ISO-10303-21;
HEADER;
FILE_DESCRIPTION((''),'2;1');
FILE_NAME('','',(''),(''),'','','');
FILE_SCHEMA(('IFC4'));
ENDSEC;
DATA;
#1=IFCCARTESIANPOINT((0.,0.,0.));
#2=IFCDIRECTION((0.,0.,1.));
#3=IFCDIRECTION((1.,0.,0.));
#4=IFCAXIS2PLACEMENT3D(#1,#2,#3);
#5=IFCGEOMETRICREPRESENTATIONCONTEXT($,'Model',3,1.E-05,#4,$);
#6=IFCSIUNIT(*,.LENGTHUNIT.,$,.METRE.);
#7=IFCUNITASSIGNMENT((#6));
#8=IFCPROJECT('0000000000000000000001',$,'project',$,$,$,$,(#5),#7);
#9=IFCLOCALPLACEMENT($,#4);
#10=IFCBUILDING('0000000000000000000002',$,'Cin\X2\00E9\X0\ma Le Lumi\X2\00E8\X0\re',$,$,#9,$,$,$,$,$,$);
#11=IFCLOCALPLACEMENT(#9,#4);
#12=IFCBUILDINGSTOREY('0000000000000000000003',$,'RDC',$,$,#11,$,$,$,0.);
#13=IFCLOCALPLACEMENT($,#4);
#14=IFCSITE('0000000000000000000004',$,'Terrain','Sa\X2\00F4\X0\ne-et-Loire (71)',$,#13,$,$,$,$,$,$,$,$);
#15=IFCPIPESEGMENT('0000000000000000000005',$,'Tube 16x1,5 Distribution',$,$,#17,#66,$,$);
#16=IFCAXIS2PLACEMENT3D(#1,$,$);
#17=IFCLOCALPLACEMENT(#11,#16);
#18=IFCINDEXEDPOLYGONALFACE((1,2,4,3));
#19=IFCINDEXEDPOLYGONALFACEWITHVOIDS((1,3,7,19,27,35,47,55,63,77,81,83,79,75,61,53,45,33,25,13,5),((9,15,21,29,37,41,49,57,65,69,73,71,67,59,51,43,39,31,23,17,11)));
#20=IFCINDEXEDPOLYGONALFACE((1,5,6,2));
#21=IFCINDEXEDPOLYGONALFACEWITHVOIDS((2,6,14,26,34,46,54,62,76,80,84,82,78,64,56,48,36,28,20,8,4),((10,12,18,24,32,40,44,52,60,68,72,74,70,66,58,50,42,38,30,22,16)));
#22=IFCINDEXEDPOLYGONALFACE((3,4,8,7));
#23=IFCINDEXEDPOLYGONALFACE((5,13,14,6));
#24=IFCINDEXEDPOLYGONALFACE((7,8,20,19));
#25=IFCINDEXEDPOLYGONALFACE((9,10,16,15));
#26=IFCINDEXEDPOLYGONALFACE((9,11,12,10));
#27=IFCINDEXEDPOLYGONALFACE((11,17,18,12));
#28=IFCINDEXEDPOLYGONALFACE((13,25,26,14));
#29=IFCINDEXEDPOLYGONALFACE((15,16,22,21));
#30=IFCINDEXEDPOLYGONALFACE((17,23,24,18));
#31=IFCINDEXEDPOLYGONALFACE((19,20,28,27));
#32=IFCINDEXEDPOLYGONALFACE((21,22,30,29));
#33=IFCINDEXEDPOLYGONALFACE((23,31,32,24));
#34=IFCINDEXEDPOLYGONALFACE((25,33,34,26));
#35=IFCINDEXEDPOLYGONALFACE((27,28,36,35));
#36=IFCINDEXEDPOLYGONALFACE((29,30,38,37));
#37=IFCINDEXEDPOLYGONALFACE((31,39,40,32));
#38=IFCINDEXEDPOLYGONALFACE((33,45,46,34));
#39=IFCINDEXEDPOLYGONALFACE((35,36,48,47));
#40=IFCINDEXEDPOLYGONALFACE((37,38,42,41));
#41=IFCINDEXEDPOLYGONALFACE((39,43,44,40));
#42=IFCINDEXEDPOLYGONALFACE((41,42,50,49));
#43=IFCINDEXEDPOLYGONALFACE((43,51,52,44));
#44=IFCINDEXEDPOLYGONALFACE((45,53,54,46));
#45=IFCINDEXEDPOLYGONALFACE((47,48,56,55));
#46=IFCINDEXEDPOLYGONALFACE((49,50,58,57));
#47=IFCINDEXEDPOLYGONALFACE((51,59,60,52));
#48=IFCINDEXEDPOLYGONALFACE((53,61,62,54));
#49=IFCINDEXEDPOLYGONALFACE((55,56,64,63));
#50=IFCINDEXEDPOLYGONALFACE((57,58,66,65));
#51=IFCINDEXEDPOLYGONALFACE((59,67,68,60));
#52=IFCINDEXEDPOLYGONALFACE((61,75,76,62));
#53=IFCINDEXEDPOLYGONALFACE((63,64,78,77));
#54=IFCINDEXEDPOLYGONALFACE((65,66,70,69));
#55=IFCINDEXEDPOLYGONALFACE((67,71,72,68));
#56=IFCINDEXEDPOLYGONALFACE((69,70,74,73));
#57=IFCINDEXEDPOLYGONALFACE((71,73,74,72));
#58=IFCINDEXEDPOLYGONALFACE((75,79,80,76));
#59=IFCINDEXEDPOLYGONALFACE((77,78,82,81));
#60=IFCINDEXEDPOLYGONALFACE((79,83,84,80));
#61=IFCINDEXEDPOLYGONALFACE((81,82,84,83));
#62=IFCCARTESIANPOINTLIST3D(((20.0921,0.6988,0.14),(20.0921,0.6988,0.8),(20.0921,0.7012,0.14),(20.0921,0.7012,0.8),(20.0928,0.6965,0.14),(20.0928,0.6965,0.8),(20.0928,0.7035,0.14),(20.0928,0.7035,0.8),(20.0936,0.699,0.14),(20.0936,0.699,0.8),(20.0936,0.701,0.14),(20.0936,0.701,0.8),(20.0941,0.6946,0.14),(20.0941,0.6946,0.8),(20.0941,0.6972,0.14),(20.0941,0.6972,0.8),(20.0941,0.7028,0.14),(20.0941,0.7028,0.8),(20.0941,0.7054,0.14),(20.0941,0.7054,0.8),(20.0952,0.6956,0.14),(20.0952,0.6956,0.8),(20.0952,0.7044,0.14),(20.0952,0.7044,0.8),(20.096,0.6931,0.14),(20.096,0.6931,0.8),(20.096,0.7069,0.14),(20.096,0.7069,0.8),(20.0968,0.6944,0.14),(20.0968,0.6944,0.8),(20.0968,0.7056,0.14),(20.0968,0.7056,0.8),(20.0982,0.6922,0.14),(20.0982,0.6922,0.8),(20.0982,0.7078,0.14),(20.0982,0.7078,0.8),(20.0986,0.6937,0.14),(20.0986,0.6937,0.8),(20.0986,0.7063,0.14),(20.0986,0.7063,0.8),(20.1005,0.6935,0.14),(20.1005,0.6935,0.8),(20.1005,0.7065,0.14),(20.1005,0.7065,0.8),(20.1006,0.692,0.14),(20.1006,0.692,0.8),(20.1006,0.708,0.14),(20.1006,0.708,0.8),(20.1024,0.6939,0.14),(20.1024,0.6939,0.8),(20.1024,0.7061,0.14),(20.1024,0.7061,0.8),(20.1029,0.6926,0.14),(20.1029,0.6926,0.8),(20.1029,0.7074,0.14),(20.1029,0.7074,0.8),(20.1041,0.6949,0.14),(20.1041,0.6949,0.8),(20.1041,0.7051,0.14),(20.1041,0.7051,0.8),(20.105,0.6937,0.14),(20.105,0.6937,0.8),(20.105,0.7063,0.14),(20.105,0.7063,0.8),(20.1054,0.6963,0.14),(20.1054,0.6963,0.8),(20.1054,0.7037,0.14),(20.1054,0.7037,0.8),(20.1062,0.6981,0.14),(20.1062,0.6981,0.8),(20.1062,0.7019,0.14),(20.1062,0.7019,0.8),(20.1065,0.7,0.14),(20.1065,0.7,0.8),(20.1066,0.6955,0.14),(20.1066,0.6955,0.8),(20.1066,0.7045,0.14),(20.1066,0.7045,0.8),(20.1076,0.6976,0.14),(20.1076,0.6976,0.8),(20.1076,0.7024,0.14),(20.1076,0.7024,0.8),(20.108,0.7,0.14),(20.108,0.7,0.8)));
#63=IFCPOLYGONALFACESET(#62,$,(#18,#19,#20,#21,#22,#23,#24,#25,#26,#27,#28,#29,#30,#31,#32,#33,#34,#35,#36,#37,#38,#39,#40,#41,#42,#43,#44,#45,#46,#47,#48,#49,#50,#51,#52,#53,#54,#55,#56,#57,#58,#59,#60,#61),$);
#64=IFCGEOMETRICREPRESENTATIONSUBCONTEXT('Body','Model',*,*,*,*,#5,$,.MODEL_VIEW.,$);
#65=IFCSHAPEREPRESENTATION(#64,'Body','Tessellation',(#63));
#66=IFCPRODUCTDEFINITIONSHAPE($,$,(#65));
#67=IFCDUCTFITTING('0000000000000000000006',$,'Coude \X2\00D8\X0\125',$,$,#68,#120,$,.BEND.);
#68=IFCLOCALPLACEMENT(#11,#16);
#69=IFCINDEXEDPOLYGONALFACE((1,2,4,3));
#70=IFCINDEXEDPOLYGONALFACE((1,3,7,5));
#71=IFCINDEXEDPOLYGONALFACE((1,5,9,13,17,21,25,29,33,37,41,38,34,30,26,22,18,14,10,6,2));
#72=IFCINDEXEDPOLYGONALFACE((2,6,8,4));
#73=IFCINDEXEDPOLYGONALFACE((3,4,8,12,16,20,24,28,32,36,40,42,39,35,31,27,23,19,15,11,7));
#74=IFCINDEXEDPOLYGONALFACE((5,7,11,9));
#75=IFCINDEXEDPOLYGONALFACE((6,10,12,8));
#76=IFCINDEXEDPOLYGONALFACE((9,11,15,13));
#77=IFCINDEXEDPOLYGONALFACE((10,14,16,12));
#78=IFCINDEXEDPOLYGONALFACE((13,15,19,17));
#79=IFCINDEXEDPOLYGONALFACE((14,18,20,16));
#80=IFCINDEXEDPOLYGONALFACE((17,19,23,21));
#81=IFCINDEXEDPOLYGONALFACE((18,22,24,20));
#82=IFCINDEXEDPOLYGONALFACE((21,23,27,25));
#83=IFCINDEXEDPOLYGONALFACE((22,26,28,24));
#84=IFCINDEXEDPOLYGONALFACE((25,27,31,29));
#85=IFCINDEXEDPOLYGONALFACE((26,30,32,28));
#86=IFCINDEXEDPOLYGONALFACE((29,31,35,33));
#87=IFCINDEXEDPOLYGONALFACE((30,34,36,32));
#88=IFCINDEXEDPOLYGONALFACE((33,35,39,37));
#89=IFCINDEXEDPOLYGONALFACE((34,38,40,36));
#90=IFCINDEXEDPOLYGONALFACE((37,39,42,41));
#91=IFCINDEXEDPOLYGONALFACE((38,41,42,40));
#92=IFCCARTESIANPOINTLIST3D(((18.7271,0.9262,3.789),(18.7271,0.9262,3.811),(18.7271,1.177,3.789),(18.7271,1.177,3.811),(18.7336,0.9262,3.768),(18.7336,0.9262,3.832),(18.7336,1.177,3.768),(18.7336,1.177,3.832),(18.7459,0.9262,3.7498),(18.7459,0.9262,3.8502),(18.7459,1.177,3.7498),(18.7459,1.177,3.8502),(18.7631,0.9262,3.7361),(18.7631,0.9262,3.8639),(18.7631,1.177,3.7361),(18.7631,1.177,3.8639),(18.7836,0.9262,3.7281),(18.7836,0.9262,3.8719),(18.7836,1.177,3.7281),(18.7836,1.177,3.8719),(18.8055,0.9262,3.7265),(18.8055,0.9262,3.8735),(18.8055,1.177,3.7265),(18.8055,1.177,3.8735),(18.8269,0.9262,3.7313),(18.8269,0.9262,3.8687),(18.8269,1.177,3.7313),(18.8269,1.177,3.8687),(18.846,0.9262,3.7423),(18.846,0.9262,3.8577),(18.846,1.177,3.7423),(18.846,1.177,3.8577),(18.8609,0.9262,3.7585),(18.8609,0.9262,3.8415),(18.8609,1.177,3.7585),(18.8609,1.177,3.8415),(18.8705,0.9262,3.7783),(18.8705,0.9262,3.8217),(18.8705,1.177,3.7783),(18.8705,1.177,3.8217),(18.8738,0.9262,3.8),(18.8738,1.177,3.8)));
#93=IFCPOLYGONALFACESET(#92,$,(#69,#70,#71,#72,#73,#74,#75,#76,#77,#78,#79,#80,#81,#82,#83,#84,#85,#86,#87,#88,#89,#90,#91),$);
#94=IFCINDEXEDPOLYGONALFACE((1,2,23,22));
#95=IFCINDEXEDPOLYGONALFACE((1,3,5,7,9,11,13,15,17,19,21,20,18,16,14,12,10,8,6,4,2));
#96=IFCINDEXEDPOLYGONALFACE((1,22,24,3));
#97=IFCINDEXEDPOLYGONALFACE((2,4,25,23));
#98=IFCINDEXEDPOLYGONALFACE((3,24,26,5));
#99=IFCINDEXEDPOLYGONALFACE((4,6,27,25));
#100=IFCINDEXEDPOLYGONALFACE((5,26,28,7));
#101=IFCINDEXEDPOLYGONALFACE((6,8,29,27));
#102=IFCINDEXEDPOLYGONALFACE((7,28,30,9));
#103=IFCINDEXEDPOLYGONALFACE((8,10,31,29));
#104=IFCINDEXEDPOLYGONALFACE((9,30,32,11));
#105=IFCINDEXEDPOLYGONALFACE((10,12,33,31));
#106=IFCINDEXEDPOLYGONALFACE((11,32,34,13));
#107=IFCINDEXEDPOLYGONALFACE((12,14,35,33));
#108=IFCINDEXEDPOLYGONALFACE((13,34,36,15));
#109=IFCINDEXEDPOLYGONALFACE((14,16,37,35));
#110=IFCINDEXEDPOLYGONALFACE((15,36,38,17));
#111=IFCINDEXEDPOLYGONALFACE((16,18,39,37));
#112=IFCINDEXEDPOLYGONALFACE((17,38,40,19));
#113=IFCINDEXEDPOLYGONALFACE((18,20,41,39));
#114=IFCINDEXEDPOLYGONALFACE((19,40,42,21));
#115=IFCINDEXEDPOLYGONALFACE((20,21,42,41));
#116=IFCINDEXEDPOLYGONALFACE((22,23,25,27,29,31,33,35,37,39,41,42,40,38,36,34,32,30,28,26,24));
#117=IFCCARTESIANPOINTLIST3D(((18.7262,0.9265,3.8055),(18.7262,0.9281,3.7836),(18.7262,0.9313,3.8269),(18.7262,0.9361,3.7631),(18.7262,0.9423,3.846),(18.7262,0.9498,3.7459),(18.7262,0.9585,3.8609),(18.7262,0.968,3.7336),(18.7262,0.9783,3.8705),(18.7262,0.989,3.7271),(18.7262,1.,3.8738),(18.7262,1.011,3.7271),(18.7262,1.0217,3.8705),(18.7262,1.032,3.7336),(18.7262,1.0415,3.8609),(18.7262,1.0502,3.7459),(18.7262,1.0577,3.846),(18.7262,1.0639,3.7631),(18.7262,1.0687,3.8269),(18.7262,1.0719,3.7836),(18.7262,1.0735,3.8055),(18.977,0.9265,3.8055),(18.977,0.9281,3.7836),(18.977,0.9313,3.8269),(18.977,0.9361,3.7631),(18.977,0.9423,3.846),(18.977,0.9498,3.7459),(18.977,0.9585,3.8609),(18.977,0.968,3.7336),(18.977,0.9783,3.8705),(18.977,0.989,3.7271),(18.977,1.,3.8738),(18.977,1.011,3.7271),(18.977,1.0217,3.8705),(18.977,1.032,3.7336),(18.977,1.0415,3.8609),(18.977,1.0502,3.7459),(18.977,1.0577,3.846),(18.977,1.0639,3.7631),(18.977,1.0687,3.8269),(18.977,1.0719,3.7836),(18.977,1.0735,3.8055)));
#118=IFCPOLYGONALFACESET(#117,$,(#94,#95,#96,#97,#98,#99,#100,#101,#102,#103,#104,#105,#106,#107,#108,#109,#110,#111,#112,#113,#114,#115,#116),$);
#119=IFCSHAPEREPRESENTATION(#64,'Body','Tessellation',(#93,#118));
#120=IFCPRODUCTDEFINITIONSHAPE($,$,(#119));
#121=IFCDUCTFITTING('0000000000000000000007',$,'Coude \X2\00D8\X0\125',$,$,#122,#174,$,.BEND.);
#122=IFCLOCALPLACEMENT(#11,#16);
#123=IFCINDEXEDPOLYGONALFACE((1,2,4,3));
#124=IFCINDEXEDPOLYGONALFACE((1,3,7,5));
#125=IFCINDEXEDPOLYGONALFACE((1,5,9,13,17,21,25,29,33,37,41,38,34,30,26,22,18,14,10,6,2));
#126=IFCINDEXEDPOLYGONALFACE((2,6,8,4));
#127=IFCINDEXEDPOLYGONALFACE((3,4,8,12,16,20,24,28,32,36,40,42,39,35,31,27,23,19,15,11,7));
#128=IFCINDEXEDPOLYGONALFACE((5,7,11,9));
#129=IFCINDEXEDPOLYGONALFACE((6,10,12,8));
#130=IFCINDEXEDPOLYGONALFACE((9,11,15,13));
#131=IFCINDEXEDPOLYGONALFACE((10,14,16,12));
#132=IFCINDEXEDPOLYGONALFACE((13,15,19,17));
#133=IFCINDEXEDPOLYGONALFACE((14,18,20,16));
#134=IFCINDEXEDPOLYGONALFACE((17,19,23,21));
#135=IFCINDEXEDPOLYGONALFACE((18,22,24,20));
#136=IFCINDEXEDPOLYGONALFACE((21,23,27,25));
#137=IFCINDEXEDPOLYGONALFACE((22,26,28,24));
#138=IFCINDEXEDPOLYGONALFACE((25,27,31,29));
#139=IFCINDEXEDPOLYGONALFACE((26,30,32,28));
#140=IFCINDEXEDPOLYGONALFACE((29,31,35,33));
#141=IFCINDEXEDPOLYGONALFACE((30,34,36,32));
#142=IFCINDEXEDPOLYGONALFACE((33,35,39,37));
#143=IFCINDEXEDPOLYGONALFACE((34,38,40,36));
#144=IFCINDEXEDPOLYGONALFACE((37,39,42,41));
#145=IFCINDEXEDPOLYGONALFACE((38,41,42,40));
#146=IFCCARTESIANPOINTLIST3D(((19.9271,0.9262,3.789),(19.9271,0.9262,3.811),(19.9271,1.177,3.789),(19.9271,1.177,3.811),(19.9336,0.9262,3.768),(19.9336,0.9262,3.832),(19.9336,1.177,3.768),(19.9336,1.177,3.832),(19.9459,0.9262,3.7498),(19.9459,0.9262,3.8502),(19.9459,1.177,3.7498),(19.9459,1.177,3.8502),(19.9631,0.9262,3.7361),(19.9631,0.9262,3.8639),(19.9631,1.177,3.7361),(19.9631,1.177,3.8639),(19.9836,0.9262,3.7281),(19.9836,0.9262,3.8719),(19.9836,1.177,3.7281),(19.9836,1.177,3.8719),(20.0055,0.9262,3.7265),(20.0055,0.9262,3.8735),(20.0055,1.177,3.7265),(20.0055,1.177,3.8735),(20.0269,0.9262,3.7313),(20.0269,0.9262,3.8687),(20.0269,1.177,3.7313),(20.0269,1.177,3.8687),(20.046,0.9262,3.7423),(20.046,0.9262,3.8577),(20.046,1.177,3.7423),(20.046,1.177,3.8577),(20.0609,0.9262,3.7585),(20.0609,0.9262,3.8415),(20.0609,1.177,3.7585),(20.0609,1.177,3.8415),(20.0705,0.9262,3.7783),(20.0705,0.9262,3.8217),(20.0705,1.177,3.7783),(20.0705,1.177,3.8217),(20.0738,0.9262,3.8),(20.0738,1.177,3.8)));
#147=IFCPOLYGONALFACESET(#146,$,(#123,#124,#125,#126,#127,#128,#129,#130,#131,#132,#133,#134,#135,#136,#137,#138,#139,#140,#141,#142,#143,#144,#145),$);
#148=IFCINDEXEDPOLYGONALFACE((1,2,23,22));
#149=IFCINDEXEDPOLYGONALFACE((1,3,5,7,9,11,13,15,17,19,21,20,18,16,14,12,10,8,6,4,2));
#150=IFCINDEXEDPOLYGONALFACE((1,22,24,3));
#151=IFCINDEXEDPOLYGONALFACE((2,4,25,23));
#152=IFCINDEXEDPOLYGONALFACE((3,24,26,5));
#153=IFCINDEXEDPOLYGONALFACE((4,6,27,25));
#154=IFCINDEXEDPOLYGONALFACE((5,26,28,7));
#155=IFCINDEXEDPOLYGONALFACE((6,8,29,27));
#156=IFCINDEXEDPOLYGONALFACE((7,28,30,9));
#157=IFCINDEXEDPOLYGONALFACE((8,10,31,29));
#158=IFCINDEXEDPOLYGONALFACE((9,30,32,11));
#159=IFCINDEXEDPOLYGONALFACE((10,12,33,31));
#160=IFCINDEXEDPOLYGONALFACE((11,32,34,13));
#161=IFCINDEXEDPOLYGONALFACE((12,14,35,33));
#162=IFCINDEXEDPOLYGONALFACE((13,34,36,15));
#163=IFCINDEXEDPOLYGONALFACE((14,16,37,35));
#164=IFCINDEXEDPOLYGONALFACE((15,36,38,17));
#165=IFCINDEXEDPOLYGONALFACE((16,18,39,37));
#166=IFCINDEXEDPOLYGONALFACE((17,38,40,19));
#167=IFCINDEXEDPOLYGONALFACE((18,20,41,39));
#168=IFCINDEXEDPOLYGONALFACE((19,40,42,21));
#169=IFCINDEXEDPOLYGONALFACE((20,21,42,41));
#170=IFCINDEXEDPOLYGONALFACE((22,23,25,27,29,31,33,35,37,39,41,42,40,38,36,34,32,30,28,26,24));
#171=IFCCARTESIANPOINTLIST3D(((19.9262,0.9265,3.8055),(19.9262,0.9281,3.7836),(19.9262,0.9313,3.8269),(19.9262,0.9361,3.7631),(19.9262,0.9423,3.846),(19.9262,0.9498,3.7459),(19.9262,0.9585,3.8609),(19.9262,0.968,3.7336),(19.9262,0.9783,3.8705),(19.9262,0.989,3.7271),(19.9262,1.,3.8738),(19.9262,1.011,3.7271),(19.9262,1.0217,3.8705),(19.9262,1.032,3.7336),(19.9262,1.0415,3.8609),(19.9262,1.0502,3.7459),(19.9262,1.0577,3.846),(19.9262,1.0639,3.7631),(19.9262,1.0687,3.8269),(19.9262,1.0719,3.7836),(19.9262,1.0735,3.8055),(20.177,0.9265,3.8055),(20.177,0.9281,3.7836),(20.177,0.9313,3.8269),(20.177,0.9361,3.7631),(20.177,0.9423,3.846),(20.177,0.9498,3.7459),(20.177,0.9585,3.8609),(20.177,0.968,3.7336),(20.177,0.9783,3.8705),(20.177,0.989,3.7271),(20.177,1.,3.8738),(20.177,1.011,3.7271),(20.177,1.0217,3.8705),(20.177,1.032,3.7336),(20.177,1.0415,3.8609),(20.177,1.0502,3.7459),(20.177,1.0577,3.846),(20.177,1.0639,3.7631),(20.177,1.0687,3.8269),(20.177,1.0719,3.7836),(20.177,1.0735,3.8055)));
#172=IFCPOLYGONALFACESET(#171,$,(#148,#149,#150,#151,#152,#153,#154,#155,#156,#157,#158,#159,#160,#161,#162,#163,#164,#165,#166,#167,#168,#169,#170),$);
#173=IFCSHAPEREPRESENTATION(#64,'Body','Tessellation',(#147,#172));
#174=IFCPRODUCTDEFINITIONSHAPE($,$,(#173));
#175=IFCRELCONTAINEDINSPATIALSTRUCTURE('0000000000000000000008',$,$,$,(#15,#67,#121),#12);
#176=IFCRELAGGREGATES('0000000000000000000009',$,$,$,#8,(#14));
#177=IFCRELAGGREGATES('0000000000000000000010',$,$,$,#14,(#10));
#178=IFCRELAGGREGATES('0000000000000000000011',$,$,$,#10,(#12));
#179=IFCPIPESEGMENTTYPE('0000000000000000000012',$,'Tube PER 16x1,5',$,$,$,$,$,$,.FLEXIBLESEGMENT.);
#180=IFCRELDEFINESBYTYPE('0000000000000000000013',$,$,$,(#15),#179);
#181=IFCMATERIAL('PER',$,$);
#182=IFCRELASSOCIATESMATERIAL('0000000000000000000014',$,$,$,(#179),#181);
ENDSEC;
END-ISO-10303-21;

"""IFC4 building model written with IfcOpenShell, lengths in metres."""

from ifc_helpers import new_model, si_unit, frame, origin_with_axes, place, context, subcontext, project, spatial, circle, hollow_circle, extrude, material, type_object, element, save


model = new_model("IFC4")

# Units and contexts
model_context = context("Model", 3, precision=1e-05, world=origin_with_axes())
body_context = subcontext(model_context, "Body", "Model", "MODEL_VIEW")
ifc_project = project(units=[si_unit("LENGTHUNIT", "METRE")], contexts=[model_context])

# Site, building, storey
site_placement = place(None, origin_with_axes())
site = spatial("IfcSite", under=ifc_project, at=site_placement, Name="Terrain", Description="Saône-et-Loire (71)")
building_placement = place(None, origin_with_axes())
building = spatial("IfcBuilding", under=site, at=building_placement, Name="Cinéma Le Lumière")
storey_placement = place(building_placement, origin_with_axes())
storey = spatial("IfcBuildingStorey", under=building, at=storey_placement, Name="RDC", Elevation=0.0)

# Pipe segment
ifc_material_1 = material(Name="PER")
pipe_segment_type = type_object("IfcPipeSegmentType", Name="Tube PER 16x1,5", PredefinedType="FLEXIBLESEGMENT", material=ifc_material_1)
pipe_segment_1_placement = place(storey_placement, frame((20.1, 0.7, 0.14), z_axis=(0.0, 0.0, 1.0), x_axis=(1.0, 0.0, 0.0)))
element("IfcPipeSegment", 1, at=pipe_segment_1_placement, inside=storey, type_object=pipe_segment_type, Name="Tube 16x1,5 Distribution", context=body_context, shape_type="SweptSolid", body=[
    extrude(hollow_circle(Radius=0.008, WallThickness=0.0015), origin_with_axes(), (0.0, 0.0, 1.0), 0.66),
])

# Duct fitting
duct_fitting_1_placement = place(storey_placement, frame((18.8, 1.0, 3.8), z_axis=(0.0, 0.0, 1.0), x_axis=(1.0, 0.0, 0.0)))
element("IfcDuctFitting", 2, at=duct_fitting_1_placement, inside=storey, Name="Coude Ø125", PredefinedType="BEND", context=body_context, shape_type="SweptSolid", body=[
    extrude(circle(Radius=0.0737), frame((0.0, -0.0737, 0.0), z_axis=(0.0, 1.0, 0.0), x_axis=(1.0, 0.0, 0.0)), (0.0, 0.0, 1.0), 0.2507),
    extrude(circle(Radius=0.0737), frame((-0.0737, 0.0, 0.0), z_axis=(1.0, 0.0, 0.0), x_axis=(0.0, 0.0, 1.0)), (0.0, 0.0, 1.0), 0.2507),
])

# Duct fitting
duct_fitting_2_placement = place(storey_placement, frame((20.0, 1.0, 3.8), z_axis=(0.0, 0.0, 1.0), x_axis=(1.0, 0.0, 0.0)))
element("IfcDuctFitting", 3, at=duct_fitting_2_placement, inside=storey, Name="Coude Ø125", PredefinedType="BEND", context=body_context, shape_type="SweptSolid", body=[
    extrude(circle(Radius=0.0737), frame((0.0, -0.0737, 0.0), z_axis=(0.0, 1.0, 0.0), x_axis=(1.0, 0.0, 0.0)), (0.0, 0.0, 1.0), 0.2507),
    extrude(circle(Radius=0.0737), frame((-0.0737, 0.0, 0.0), z_axis=(1.0, 0.0, 0.0), x_axis=(0.0, 0.0, 1.0)), (0.0, 0.0, 1.0), 0.2507),
])

save(model, "model.ifc")
